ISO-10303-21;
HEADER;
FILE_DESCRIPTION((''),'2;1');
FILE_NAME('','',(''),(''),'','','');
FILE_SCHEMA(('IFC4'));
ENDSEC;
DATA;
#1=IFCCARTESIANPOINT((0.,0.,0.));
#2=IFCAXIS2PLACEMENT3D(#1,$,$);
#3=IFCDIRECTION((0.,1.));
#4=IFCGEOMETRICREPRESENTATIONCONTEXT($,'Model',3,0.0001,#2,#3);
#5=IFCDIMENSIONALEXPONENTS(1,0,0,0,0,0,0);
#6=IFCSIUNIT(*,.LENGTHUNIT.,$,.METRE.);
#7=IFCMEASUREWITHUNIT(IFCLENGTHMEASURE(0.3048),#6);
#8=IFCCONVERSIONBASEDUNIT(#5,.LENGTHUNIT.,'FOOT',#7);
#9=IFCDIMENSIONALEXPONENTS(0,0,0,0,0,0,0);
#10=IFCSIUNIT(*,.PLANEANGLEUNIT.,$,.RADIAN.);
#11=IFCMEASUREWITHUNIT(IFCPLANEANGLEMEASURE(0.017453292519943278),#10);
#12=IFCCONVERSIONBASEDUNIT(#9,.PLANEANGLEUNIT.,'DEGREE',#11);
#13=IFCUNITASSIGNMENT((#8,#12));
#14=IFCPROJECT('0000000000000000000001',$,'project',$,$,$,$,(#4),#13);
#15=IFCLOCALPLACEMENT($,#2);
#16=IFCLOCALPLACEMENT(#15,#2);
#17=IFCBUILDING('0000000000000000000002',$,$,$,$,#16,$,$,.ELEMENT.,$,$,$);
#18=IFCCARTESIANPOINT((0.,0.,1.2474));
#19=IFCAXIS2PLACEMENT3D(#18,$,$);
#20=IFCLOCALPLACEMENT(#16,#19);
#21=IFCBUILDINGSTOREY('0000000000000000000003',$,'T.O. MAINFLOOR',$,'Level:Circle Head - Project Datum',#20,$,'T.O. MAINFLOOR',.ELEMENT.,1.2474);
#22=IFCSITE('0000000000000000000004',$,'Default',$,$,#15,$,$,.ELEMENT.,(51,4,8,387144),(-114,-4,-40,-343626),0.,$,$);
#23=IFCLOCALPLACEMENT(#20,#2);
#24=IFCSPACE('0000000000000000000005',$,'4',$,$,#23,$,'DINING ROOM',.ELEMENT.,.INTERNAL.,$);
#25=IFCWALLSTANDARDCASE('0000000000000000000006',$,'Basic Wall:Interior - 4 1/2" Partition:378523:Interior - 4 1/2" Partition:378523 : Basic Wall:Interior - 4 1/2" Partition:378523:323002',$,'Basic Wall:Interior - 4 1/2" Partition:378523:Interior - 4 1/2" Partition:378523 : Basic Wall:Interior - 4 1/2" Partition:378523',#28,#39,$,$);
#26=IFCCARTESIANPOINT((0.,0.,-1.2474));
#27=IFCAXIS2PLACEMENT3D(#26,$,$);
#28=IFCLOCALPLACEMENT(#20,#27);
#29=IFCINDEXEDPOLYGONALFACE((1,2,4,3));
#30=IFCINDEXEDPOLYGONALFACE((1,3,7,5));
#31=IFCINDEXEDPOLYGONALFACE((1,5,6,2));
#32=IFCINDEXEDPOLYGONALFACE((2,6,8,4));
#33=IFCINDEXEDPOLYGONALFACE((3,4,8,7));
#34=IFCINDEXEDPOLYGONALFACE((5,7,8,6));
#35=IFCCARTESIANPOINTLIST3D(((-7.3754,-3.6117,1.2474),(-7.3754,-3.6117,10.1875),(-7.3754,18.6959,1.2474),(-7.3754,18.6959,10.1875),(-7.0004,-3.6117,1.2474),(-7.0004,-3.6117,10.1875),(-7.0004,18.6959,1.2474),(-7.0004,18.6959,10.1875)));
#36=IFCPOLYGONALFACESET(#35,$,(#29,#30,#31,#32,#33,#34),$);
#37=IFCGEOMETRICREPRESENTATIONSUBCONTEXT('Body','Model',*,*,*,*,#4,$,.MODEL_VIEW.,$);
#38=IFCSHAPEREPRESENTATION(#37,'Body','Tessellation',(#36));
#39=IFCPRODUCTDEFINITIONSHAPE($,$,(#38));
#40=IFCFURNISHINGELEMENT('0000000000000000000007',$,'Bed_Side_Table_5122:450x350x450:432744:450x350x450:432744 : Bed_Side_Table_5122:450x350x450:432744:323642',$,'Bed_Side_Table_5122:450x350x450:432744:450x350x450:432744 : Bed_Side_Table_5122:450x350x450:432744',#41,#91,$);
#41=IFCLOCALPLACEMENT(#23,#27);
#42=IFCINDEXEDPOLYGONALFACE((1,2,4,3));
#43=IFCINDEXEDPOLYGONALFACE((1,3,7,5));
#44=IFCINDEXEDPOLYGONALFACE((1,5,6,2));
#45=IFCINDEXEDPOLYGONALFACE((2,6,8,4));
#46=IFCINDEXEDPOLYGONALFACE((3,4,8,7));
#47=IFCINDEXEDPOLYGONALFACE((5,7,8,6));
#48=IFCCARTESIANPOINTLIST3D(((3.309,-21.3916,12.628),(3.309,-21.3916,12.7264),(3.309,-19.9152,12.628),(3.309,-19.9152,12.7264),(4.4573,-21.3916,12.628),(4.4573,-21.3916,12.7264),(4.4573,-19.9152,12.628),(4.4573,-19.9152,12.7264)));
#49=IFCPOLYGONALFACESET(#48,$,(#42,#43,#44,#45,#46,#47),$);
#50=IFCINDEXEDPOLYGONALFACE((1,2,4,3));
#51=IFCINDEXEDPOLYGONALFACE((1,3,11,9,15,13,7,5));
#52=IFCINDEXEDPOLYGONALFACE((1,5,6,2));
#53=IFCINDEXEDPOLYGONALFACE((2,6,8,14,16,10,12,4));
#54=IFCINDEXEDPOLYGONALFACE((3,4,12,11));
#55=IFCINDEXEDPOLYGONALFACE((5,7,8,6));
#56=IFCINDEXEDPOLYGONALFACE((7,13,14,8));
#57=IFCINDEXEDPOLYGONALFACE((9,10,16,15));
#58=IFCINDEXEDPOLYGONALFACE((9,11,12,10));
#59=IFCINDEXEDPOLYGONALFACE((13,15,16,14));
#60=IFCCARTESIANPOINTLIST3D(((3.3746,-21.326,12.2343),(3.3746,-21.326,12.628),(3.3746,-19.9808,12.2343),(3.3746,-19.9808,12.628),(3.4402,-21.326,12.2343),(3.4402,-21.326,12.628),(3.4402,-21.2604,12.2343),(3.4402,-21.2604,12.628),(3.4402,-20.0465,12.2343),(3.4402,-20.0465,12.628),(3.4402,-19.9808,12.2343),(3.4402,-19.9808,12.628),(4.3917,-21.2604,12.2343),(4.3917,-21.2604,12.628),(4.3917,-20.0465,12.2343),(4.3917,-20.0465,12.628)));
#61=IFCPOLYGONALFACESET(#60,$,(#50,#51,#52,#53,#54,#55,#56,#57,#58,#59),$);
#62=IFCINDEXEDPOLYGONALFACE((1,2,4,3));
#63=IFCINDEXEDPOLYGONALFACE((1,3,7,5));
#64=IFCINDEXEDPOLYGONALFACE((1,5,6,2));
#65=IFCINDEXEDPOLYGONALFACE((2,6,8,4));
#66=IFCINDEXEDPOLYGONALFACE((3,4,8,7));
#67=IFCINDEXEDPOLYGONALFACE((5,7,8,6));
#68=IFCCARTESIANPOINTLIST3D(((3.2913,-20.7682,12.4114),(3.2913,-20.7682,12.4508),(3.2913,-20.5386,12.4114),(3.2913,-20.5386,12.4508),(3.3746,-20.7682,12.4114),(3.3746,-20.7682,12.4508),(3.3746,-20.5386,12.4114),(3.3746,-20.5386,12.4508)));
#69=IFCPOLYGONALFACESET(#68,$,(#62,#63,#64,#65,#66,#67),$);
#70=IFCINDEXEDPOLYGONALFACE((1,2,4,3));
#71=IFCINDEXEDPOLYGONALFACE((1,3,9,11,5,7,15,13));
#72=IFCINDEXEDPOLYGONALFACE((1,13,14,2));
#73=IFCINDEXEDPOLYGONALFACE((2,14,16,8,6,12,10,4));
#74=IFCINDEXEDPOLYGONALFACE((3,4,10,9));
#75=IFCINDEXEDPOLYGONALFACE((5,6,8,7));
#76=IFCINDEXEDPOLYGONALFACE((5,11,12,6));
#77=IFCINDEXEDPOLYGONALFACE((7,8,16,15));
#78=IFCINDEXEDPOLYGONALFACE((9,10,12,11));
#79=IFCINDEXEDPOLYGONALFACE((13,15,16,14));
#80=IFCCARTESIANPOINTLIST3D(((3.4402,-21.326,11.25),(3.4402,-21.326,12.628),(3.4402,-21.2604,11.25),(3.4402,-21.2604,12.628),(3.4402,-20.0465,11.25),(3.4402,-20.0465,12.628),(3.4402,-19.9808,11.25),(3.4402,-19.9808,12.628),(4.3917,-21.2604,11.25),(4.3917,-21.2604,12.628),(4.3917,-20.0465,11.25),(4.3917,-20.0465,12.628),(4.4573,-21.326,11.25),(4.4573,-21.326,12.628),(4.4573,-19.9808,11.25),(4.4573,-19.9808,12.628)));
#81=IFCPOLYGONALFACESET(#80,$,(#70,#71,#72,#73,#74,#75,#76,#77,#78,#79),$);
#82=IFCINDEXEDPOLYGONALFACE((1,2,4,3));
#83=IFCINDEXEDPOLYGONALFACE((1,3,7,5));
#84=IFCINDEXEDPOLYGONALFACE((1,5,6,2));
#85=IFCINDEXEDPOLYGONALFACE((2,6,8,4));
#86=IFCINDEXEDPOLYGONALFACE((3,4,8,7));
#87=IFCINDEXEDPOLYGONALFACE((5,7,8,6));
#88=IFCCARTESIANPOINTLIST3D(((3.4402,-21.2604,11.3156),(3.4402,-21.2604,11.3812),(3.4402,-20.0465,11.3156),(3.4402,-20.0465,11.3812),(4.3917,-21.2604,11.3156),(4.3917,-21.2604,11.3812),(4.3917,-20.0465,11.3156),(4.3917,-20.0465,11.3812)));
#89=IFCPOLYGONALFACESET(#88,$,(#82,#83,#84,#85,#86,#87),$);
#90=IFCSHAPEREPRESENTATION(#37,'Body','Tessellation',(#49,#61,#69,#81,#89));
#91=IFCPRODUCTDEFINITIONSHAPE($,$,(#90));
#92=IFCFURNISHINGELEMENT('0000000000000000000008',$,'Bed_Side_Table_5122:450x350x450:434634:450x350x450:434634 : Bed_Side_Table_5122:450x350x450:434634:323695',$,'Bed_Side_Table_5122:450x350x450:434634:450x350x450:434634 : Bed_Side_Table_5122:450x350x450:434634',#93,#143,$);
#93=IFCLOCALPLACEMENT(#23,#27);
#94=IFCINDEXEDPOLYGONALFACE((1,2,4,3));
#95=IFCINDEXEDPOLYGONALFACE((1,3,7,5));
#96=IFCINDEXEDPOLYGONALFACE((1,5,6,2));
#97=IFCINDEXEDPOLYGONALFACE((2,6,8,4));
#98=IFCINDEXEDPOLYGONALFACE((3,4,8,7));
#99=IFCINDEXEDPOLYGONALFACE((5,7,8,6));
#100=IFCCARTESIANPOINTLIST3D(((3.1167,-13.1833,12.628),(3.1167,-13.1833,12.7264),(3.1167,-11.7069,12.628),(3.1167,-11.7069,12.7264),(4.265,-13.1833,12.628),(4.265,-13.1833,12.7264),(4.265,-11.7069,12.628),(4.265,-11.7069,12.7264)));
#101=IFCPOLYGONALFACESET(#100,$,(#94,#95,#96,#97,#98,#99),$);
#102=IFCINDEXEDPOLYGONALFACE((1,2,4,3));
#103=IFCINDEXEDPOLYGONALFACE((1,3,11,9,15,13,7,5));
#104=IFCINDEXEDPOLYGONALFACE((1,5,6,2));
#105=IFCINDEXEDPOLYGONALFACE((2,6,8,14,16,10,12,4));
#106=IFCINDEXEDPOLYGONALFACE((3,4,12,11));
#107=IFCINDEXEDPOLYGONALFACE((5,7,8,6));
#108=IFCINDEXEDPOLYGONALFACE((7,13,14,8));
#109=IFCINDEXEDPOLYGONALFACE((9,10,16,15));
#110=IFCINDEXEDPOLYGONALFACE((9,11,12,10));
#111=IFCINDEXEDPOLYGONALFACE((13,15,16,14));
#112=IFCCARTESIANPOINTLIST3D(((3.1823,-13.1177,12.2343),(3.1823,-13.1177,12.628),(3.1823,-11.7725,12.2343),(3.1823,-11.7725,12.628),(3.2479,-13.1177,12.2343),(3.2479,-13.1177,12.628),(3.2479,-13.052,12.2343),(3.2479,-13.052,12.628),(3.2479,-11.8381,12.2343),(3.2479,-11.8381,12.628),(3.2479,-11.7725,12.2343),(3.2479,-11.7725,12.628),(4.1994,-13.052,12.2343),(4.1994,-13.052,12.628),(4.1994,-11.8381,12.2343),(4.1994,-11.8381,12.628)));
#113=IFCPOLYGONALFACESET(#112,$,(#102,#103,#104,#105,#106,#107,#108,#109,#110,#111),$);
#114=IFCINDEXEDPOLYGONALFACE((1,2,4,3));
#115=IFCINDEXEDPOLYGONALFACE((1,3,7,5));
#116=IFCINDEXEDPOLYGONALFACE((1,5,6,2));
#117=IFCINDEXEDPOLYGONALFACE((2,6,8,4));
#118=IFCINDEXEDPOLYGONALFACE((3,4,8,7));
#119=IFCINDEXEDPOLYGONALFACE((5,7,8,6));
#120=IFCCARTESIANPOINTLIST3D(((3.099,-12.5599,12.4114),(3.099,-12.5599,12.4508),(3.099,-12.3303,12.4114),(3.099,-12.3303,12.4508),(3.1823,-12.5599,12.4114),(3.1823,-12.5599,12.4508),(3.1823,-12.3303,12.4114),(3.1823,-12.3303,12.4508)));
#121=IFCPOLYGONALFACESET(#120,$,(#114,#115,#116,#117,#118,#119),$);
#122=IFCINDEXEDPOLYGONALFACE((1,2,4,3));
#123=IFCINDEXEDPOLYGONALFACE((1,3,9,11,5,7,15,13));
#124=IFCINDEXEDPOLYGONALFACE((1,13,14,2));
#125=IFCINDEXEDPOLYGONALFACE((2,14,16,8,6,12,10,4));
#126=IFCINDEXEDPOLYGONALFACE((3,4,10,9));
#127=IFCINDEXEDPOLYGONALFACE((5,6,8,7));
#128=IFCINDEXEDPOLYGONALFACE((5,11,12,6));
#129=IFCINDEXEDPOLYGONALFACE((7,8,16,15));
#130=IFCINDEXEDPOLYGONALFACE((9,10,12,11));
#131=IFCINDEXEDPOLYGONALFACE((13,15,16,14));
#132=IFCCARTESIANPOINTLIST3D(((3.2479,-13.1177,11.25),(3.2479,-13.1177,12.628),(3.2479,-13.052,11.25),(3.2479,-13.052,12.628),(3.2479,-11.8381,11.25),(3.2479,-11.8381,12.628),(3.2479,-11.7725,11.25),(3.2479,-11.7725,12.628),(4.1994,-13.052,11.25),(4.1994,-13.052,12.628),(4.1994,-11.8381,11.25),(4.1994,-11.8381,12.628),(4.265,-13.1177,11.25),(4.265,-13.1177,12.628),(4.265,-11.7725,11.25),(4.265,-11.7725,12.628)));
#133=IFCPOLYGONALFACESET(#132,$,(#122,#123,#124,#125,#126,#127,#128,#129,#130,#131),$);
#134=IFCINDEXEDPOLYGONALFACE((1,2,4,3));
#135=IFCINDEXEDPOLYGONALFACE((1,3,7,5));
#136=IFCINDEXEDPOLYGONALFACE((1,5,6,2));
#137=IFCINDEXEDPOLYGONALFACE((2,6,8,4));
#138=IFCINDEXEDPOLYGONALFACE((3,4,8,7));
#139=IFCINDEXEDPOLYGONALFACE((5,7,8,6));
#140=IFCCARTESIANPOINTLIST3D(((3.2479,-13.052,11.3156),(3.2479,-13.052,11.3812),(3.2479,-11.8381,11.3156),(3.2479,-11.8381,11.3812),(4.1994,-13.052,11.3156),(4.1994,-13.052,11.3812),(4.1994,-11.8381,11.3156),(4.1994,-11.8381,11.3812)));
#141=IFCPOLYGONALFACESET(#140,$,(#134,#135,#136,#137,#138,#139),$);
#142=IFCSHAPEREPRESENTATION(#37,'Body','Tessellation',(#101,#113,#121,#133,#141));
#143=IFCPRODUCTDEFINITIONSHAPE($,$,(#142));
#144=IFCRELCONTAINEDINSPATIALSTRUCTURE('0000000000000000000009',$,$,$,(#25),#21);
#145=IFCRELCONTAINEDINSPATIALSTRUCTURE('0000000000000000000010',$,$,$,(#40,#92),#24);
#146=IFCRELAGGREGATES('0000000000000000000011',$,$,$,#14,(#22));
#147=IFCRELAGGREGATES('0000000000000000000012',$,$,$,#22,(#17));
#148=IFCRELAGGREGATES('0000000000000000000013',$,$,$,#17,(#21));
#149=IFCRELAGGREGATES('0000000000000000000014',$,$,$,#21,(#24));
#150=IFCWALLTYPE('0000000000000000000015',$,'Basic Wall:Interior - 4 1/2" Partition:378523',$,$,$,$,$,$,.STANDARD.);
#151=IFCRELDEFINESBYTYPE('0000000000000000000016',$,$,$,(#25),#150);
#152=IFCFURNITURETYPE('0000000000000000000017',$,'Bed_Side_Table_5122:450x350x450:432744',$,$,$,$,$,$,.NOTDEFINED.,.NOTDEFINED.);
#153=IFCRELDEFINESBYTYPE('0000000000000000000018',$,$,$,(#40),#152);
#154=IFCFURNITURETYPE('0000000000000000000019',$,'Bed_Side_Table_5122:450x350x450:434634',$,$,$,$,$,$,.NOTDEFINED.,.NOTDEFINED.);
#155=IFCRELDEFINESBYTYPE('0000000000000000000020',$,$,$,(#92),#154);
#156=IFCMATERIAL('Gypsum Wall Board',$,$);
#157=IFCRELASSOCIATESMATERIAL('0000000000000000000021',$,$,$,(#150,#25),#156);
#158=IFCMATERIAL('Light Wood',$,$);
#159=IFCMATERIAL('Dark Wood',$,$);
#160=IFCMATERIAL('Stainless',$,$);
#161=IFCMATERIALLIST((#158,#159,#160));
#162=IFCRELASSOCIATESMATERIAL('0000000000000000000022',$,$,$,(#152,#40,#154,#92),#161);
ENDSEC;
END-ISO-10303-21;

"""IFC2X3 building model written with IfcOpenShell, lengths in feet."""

from ifc_helpers import new_model, entity, si_unit, converted_unit, direction, frame, frame_2d, origin, origin_2d_with_axis, place, context, subcontext, project, spatial, polyline, rectangle, outline, extrude, source, transform, mapped, material, material_list, type_object, type_shapes, element, save


model = new_model("IFC2X3")

# Units and contexts
model_context = context("Model", 3, precision=0.0001, world=origin(), true_north=direction((0.0, 1.0)))
body_context = subcontext(model_context, "Body", "Model", "MODEL_VIEW")
ifc_project = project(units=[converted_unit("LENGTHUNIT", "FOOT", entity("IfcLengthMeasure", 0.3048), si_unit("LENGTHUNIT", "METRE"), dimensions=[1, 0, 0, 0, 0, 0, 0]), converted_unit("PLANEANGLEUNIT", "DEGREE", entity("IfcPlaneAngleMeasure", 0.017453292519943278), si_unit("PLANEANGLEUNIT", "RADIAN"), dimensions=[0, 0, 0, 0, 0, 0, 0])], contexts=[model_context])

# Site, building, storey
site_placement = place(None, origin())
site = spatial("IfcSite", under=ifc_project, at=site_placement, Name="Default", CompositionType="ELEMENT", RefLatitude=(51, 4, 8, 387144), RefLongitude=(-114, -4, -40, -343626), RefElevation=0.0)
building_placement = place(site_placement, origin())
building = spatial("IfcBuilding", under=site, at=building_placement, CompositionType="ELEMENT")
storey_placement = place(building_placement, frame((0.0, 0.0, 1.2474)))
storey = spatial("IfcBuildingStorey", under=building, at=storey_placement, Name="T.O. MAINFLOOR", ObjectType="Level:Circle Head - Project Datum", LongName="T.O. MAINFLOOR", CompositionType="ELEMENT", Elevation=1.2474)

# Wall
ifc_material_1 = material(Name="Gypsum Wall Board")
wall_type_1 = type_object("IfcWallType", Name="Basic Wall:Interior - 4 1/2\" Partition:378523", PredefinedType="STANDARD", material=ifc_material_1)
shared_shape_1 = source(origin(), body_context, "Body", "SweptSolid", [
    extrude(rectangle(XDim=22.3077, YDim=0.375, at=origin_2d_with_axis()), frame((-7.1879, 7.5421, 1.2474), z_axis=(0.0, 0.0, 1.0), x_axis=(0.0, 1.0, 0.0)), (0.0, 0.0, 1.0), 8.9401),
])
type_shapes(wall_type_1, [shared_shape_1])
wall_1_placement = place(storey_placement, frame((0.0, 0.0, -1.2474)))
element("IfcWallStandardCase", 1, at=wall_1_placement, inside=storey, type_object=wall_type_1, material=ifc_material_1, Name="Basic Wall:Interior - 4 1/2\" Partition:378523:Interior - 4 1/2\" Partition:378523 : Basic Wall:Interior - 4 1/2\" Partition:378523:323002", ObjectType="Basic Wall:Interior - 4 1/2\" Partition:378523:Interior - 4 1/2\" Partition:378523 : Basic Wall:Interior - 4 1/2\" Partition:378523", context=body_context, shape_type="MappedRepresentation", body=[
    mapped(shared_shape_1, transform((0.0, 0.0, 0.0), scale=1.0)),
])

# Shared definitions
space_placement = place(storey_placement, origin())
space = spatial("IfcSpace", under=storey, at=space_placement, Name="4", LongName="DINING ROOM", CompositionType="ELEMENT", InteriorOrExteriorSpace="INTERNAL")

# Furnishing elements
ifc_material_2 = material(Name="Light Wood")
ifc_material_3 = material(Name="Dark Wood")
ifc_material_4 = material(Name="Stainless")
ifc_material_list_1 = material_list([ifc_material_2, ifc_material_3, ifc_material_4])
furniture_type_1 = type_object("IfcFurnitureType", Name="Bed_Side_Table_5122:450x350x450:432744", AssemblyPlace="NOTDEFINED", material=ifc_material_list_1)
shared_shape_2 = source(origin(), body_context, "Body", "SweptSolid", [
    extrude(rectangle(XDim=1.1483, YDim=1.4764, at=origin_2d_with_axis()), frame((3.8832, -20.6534, 12.628), z_axis=(0.0, 0.0, 1.0), x_axis=(-1.0, 0.0, 0.0)), (0.0, 0.0, 1.0), 0.0984),
    extrude(outline(polyline([(-0.2215, -0.607), (0.73, -0.607), (0.73, 0.607), (-0.2215, 0.607), (-0.2215, 0.6726), (-0.2871, 0.6726), (-0.2871, -0.6726), (-0.2215, -0.6726), (-0.2215, -0.607)])), frame((3.6617, -20.6534, 12.2343)), (0.0, 0.0, 1.0), 0.3937),
    extrude(rectangle(XDim=0.0833, YDim=0.2297, at=origin_2d_with_axis()), frame((3.333, -20.6534, 12.4114)), (0.0, 0.0, 1.0), 0.0394),
    extrude(outline(polyline([(-0.6726, -0.5249), (0.6726, -0.5249), (0.6726, 0.4921), (0.607, 0.4921), (0.607, -0.4593), (-0.607, -0.4593), (-0.607, 0.4921), (-0.6726, 0.4921), (-0.6726, -0.5249)])), frame((3.9324, -20.6534, 11.25), z_axis=(0.0, 0.0, 1.0), x_axis=(0.0, 1.0, 0.0)), (0.0, 0.0, 1.0), 1.378),
    extrude(rectangle(XDim=0.9514, YDim=1.2139, at=frame_2d((0.0, 0.0), x_axis=(1.0, 0.0))), frame((3.916, -20.6534, 11.3156)), (0.0, 0.0, 1.0), 0.0656),
])
type_shapes(furniture_type_1, [shared_shape_2])
furnishing_1_placement = place(space_placement, frame((0.0, 0.0, -1.2474)))
element("IfcFurnishingElement", 2, at=furnishing_1_placement, inside=space, type_object=furniture_type_1, material=ifc_material_list_1, Name="Bed_Side_Table_5122:450x350x450:432744:450x350x450:432744 : Bed_Side_Table_5122:450x350x450:432744:323642", ObjectType="Bed_Side_Table_5122:450x350x450:432744:450x350x450:432744 : Bed_Side_Table_5122:450x350x450:432744", context=body_context, shape_type="MappedRepresentation", body=[
    mapped(shared_shape_2, transform((0.0, 0.0, 0.0), scale=1.0)),
])
furniture_type_2 = type_object("IfcFurnitureType", Name="Bed_Side_Table_5122:450x350x450:434634", AssemblyPlace="NOTDEFINED", material=ifc_material_list_1)
shared_shape_3 = source(origin(), body_context, "Body", "SweptSolid", [
    extrude(rectangle(XDim=1.1483, YDim=1.4764, at=frame_2d((0.0, 0.0), x_axis=(1.0, 0.0))), frame((3.6908, -12.4451, 12.628), z_axis=(0.0, 0.0, 1.0), x_axis=(-1.0, 0.0, 0.0)), (0.0, 0.0, 1.0), 0.0984),
    extrude(outline(polyline([(-0.2215, -0.607), (0.73, -0.607), (0.73, 0.607), (-0.2215, 0.607), (-0.2215, 0.6726), (-0.2871, 0.6726), (-0.2871, -0.6726), (-0.2215, -0.6726), (-0.2215, -0.607)])), frame((3.4694, -12.4451, 12.2343)), (0.0, 0.0, 1.0), 0.3937),
    extrude(rectangle(XDim=0.0833, YDim=0.2297, at=origin_2d_with_axis()), frame((3.1406, -12.4451, 12.4114)), (0.0, 0.0, 1.0), 0.0394),
    extrude(outline(polyline([(-0.6726, -0.5249), (0.6726, -0.5249), (0.6726, 0.4921), (0.607, 0.4921), (0.607, -0.4593), (-0.607, -0.4593), (-0.607, 0.4921), (-0.6726, 0.4921), (-0.6726, -0.5249)])), frame((3.74, -12.4451, 11.25), z_axis=(0.0, 0.0, 1.0), x_axis=(0.0, 1.0, 0.0)), (0.0, 0.0, 1.0), 1.378),
    extrude(rectangle(XDim=0.9514, YDim=1.2139, at=frame_2d((0.0, 0.0), x_axis=(1.0, 0.0))), frame((3.7236, -12.4451, 11.3156)), (0.0, 0.0, 1.0), 0.0656),
])
type_shapes(furniture_type_2, [shared_shape_3])
furnishing_2_placement = place(space_placement, frame((0.0, 0.0, -1.2474)))
element("IfcFurnishingElement", 3, at=furnishing_2_placement, inside=space, type_object=furniture_type_2, material=ifc_material_list_1, Name="Bed_Side_Table_5122:450x350x450:434634:450x350x450:434634 : Bed_Side_Table_5122:450x350x450:434634:323695", ObjectType="Bed_Side_Table_5122:450x350x450:434634:450x350x450:434634 : Bed_Side_Table_5122:450x350x450:434634", context=body_context, shape_type="MappedRepresentation", body=[
    mapped(shared_shape_3, transform((0.0, 0.0, 0.0), scale=1.0)),
])

save(model, "model.ifc")
